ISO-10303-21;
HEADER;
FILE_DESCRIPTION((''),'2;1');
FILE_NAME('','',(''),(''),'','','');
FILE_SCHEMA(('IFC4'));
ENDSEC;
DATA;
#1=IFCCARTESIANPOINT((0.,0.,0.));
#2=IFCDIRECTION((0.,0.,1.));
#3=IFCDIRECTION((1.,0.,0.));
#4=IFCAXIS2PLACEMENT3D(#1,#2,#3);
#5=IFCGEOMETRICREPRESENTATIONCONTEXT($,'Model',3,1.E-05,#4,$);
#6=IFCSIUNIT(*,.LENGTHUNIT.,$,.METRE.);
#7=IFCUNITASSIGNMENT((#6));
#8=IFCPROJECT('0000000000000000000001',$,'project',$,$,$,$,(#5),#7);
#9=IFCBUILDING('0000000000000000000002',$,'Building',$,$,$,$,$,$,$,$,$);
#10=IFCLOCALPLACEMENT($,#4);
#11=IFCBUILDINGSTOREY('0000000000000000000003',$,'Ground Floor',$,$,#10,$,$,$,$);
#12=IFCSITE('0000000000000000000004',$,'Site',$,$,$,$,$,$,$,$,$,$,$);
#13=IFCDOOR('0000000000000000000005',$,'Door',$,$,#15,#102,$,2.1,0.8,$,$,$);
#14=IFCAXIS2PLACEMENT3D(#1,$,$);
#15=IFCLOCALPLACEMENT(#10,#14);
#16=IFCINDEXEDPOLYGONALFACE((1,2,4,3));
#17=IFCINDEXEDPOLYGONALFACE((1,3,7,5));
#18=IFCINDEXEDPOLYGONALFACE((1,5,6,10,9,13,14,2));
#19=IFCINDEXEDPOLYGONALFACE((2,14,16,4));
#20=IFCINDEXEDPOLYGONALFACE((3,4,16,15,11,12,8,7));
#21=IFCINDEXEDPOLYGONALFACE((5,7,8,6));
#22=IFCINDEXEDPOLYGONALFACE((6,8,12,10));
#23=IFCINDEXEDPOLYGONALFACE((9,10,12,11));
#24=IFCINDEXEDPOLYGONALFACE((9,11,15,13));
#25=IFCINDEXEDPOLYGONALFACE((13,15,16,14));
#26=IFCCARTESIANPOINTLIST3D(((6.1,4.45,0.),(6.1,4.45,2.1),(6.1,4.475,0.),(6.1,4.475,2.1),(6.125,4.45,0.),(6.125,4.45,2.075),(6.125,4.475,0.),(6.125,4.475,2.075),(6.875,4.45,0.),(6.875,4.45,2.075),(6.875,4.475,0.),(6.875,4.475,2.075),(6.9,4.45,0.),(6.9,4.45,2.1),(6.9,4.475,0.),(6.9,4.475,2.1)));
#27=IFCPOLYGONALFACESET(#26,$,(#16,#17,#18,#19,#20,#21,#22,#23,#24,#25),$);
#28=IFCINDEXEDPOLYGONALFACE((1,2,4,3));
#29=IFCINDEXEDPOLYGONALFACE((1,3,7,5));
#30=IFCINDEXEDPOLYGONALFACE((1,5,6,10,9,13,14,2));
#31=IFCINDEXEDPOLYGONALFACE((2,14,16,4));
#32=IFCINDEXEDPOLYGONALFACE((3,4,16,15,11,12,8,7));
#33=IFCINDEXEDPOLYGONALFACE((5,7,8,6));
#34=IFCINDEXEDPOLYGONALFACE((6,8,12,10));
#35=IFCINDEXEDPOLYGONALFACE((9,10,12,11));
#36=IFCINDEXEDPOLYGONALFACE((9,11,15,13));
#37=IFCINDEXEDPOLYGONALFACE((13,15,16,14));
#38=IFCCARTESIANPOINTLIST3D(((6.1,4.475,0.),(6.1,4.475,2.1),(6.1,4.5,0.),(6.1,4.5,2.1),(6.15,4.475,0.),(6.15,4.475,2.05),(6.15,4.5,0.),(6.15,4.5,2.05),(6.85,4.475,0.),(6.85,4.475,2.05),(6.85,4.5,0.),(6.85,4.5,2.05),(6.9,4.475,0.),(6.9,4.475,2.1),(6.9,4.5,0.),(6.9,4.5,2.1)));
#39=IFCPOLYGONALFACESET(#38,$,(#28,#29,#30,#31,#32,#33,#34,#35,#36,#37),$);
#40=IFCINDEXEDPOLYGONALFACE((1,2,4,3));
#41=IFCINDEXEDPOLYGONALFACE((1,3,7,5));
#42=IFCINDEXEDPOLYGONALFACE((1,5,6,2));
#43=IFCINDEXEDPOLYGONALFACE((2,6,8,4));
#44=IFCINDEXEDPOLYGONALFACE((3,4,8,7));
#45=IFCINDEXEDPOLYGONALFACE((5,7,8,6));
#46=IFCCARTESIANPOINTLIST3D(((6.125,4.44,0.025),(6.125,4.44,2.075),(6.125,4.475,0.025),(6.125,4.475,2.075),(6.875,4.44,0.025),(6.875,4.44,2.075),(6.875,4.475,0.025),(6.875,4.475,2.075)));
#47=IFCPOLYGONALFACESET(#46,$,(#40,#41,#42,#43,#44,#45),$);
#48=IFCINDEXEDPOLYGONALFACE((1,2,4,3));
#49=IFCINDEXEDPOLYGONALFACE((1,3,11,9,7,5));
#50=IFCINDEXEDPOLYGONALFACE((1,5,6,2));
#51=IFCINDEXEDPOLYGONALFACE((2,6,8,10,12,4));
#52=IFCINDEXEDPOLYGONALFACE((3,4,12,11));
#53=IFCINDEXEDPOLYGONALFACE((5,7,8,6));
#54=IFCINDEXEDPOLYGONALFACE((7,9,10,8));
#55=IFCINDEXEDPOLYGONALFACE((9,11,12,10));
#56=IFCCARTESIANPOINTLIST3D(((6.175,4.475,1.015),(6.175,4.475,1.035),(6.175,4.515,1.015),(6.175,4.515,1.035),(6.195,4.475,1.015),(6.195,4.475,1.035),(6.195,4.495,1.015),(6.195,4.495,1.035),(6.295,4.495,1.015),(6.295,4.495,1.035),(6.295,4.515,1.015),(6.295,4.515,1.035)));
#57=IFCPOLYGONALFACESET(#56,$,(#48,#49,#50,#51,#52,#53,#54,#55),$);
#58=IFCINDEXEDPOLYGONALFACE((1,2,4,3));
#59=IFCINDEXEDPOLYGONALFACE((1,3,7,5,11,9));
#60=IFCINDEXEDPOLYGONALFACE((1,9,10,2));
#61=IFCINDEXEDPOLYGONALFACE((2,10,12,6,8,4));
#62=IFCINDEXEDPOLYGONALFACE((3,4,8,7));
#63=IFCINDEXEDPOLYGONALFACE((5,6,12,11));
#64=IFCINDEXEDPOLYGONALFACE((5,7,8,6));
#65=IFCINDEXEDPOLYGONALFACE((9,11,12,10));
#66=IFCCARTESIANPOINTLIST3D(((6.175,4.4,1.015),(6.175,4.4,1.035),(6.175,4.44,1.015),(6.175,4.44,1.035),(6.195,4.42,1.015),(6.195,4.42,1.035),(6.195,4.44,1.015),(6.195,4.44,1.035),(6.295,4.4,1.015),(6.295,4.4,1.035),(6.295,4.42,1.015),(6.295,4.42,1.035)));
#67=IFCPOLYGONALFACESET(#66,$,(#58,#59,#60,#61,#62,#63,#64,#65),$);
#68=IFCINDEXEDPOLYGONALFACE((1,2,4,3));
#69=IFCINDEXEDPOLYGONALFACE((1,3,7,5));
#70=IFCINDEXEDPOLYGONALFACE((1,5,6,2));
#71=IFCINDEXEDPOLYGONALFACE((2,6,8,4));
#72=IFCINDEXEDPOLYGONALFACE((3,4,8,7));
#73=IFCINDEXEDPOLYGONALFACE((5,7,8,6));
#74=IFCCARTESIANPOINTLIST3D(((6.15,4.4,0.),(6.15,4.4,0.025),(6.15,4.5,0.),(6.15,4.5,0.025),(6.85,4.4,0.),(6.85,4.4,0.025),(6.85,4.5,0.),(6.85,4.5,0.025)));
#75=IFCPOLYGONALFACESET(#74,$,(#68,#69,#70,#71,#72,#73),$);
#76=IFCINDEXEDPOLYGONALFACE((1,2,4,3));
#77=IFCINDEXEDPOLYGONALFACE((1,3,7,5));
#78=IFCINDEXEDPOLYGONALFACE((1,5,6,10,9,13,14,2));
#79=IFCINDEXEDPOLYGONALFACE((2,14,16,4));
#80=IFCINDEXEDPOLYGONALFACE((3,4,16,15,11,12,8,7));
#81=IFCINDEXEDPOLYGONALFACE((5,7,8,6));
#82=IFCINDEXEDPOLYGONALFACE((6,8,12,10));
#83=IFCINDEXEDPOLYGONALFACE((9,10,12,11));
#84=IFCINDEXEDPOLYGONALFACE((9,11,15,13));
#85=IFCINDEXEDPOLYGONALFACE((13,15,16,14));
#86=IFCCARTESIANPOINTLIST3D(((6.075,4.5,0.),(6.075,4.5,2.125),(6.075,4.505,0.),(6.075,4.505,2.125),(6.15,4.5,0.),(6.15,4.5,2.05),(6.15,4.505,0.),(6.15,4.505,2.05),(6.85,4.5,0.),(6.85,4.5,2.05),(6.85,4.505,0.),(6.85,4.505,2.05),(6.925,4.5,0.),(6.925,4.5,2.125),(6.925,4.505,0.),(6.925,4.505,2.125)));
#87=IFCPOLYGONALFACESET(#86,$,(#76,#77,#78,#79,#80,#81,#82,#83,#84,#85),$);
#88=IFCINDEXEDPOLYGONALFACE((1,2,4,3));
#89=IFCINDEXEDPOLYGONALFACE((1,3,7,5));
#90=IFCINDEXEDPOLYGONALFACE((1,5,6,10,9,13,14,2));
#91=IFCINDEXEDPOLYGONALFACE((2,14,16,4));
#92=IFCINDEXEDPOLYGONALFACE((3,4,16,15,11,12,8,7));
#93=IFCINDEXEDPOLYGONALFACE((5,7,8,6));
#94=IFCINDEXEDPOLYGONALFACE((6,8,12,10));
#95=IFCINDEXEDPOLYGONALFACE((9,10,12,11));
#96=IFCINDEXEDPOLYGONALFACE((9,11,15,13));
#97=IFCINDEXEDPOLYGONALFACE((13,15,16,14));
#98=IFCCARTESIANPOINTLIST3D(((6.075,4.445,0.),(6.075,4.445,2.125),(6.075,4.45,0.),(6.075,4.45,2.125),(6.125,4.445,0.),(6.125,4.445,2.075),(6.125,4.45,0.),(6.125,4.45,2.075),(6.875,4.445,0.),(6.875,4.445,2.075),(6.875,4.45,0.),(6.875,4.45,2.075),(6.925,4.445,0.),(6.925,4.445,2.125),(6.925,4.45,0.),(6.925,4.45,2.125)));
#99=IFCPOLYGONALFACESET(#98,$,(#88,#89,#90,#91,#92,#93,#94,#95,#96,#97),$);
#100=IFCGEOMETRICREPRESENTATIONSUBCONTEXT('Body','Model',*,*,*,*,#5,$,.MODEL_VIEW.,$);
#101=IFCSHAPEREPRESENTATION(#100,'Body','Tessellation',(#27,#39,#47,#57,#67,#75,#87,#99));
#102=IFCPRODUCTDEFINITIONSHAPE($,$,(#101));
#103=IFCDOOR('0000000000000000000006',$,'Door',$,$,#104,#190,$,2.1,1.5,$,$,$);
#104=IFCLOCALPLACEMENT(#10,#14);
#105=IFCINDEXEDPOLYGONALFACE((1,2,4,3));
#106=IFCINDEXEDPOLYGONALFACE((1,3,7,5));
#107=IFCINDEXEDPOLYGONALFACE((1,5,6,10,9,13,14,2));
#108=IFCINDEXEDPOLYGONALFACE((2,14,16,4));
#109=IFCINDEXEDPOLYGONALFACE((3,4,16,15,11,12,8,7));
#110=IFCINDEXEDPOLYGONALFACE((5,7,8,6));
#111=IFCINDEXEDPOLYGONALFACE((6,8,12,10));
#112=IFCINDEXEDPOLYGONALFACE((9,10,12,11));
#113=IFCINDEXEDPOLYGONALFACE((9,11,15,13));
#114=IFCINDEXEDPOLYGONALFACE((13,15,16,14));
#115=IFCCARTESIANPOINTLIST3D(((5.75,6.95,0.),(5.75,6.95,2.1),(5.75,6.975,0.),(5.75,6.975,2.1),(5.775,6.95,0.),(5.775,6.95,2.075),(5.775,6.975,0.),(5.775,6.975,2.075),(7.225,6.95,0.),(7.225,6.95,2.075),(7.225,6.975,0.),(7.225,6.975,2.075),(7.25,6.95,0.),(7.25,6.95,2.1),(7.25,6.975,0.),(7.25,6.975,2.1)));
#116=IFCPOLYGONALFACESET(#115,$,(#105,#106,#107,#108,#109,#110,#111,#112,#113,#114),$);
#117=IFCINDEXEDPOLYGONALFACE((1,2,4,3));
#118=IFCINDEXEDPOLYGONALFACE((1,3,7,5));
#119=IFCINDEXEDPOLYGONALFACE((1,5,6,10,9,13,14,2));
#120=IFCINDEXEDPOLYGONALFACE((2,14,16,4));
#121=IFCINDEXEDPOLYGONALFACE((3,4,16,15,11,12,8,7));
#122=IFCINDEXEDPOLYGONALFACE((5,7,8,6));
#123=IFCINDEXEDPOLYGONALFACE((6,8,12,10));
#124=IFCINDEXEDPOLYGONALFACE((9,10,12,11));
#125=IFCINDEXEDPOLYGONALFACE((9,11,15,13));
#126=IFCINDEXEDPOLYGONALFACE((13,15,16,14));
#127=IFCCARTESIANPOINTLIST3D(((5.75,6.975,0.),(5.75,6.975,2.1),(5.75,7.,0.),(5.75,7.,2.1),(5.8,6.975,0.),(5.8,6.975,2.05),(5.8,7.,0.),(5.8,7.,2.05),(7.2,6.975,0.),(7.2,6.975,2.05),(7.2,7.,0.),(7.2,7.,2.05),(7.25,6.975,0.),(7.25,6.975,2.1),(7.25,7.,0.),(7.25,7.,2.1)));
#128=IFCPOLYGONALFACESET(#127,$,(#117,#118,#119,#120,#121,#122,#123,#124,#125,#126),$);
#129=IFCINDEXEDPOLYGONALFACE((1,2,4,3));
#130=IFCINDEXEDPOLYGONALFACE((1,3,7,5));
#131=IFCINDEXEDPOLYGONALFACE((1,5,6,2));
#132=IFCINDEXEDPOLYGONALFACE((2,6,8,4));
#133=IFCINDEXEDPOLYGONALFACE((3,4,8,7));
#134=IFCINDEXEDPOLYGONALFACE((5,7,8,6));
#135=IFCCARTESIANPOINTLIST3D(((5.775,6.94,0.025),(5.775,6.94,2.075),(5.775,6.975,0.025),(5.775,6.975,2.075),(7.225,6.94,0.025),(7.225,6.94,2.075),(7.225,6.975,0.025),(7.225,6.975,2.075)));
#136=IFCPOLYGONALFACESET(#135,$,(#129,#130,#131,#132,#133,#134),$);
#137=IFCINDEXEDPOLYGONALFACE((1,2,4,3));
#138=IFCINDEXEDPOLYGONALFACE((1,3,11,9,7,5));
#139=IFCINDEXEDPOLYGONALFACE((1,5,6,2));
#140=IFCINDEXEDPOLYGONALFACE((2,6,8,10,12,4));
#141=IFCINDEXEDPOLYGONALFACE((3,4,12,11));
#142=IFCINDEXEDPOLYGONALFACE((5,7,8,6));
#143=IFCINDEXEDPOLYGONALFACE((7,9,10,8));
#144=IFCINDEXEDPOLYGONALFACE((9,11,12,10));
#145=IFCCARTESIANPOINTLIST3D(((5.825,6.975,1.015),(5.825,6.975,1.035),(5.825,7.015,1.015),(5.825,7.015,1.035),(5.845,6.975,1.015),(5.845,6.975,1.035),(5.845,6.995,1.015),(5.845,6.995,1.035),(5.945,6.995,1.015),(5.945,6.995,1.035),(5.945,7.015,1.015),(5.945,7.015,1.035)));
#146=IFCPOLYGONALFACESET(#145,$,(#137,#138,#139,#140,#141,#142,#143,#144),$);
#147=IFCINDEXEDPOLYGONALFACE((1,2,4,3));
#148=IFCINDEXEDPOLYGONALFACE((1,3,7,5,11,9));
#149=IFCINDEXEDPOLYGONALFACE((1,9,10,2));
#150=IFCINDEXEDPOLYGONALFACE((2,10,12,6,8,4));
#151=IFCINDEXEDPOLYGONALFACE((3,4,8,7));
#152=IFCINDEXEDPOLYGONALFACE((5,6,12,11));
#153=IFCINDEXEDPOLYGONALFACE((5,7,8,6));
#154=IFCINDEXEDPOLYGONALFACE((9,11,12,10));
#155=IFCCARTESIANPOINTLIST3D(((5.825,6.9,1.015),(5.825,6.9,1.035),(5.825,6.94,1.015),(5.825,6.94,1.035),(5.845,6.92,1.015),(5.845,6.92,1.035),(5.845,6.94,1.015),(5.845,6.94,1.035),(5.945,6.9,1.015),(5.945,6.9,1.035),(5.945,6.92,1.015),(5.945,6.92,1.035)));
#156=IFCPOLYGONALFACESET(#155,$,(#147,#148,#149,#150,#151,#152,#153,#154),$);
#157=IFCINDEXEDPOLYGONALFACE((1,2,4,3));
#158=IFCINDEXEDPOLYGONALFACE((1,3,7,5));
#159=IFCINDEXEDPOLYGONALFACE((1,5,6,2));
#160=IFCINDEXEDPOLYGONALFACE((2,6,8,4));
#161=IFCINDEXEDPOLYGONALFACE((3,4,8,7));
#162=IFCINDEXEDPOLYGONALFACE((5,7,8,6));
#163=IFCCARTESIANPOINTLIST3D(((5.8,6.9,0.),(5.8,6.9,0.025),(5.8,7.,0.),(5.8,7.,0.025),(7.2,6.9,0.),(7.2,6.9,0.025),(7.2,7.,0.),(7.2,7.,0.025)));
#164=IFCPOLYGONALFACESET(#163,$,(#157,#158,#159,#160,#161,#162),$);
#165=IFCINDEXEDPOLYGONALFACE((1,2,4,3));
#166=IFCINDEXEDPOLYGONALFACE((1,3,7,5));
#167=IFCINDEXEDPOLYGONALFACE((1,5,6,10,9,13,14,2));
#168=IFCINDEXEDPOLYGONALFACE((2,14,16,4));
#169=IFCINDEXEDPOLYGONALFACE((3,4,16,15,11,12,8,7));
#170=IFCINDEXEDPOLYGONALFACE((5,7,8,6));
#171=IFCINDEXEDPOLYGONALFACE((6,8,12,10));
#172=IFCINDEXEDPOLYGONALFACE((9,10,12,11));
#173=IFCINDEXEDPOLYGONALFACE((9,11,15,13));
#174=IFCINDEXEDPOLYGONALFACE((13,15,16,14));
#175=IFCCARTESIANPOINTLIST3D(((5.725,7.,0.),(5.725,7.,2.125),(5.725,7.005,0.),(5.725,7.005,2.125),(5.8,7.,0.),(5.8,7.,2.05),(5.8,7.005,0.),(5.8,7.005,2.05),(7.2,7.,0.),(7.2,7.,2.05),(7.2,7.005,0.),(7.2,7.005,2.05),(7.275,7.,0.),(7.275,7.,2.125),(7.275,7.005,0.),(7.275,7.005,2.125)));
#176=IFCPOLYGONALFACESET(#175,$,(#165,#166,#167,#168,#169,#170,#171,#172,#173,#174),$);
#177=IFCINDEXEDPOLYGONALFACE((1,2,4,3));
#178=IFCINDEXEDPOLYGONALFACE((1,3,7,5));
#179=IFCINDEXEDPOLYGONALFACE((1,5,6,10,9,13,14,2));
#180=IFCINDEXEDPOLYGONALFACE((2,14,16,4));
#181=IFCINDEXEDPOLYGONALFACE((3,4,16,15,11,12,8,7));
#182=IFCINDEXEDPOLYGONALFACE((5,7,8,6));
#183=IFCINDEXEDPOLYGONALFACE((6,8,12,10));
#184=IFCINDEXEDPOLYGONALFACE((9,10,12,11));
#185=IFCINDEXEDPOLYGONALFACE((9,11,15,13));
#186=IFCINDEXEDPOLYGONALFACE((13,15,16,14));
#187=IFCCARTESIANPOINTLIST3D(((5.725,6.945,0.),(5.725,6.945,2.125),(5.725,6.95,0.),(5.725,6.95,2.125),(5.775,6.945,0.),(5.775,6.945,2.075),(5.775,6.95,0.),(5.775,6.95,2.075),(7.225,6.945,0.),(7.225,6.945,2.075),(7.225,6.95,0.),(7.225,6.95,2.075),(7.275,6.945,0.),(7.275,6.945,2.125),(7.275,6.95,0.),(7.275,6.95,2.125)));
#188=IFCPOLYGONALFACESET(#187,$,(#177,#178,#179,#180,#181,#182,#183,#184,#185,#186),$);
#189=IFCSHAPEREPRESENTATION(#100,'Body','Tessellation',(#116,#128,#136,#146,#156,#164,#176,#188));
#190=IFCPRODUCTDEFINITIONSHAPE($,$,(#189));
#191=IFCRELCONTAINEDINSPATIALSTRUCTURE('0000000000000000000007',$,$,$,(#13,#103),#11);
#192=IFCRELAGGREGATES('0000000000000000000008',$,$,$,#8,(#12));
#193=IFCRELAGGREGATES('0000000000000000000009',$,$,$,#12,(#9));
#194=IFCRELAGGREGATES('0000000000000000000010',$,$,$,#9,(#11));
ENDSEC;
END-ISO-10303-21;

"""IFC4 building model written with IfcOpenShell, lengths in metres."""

from ifc_helpers import new_model, si_unit, frame, origin_with_axes, place, context, subcontext, project, spatial, line, indexed_curve, outline, extrude, element, save


model = new_model("IFC4")

# Units and contexts
model_context = context("Model", 3, precision=1e-05, world=origin_with_axes())
body_context = subcontext(model_context, "Body", "Model", "MODEL_VIEW")
ifc_project = project(units=[si_unit("LENGTHUNIT", "METRE")], contexts=[model_context])

# Site, building, storey
site = spatial("IfcSite", under=ifc_project, Name="Site")
building = spatial("IfcBuilding", under=site, Name="Building")
storey_placement = place(None, origin_with_axes())
storey = spatial("IfcBuildingStorey", under=building, at=storey_placement, Name="Ground Floor")

# Doors
door_1_placement = place(storey_placement, frame((6.9, 4.5, 0.0), z_axis=(0.0, 0.0, 1.0), x_axis=(-1.0, 0.0, 0.0)))
element("IfcDoor", 1, at=door_1_placement, inside=storey, Name="Door", OverallHeight=2.1, OverallWidth=0.8, context=body_context, shape_type="SweptSolid", body=[
    extrude(outline(indexed_curve([(0.0, 0.0), (0.0, 2.1), (0.8, 2.1), (0.8, 0.0), (0.775, 0.0), (0.775, 2.075), (0.025, 2.075), (0.025, 0.0)], segments=[line(1, 2, 3, 4, 5, 6, 7, 8, 1)])), frame((0.0, 0.025, 0.0), z_axis=(0.0, -1.0, 0.0), x_axis=(1.0, 0.0, 0.0)), (0.0, 0.0, -1.0), 0.025),
    extrude(outline(indexed_curve([(0.0, 0.0), (0.0, 2.1), (0.8, 2.1), (0.8, 0.0), (0.75, 0.0), (0.75, 2.05), (0.05, 2.05), (0.05, 0.0)], segments=[line(1, 2, 3, 4, 5, 6, 7, 8, 1)])), frame((0.0, 0.0, 0.0), z_axis=(0.0, -1.0, 0.0), x_axis=(1.0, 0.0, 0.0)), (0.0, 0.0, -1.0), 0.025),
    extrude(outline(indexed_curve([(0.0, 0.0), (0.75, 0.0), (0.75, 0.035), (0.0, 0.035)], segments=[line(1, 2, 3, 4, 1)])), frame((0.025, 0.025, 0.025), z_axis=(0.0, 0.0, 1.0), x_axis=(1.0, 0.0, 0.0)), (0.0, 0.0, 1.0), 2.05),
    extrude(outline(indexed_curve([(0.0, 0.0), (0.0, -0.04), (-0.12, -0.04), (-0.12, -0.02), (-0.02, -0.02), (-0.02, 0.0)], segments=[line(1, 2, 3, 4, 5, 6, 1)])), frame((0.725, 0.025, 1.015), z_axis=(0.0, 0.0, 1.0), x_axis=(1.0, 0.0, 0.0)), (0.0, 0.0, 1.0), 0.02),
    extrude(outline(indexed_curve([(0.0, 0.0), (0.0, 0.04), (-0.12, 0.04), (-0.12, 0.02), (-0.02, 0.02), (-0.02, 0.0)], segments=[line(1, 2, 3, 4, 5, 6, 1)])), frame((0.725, 0.06, 1.015), z_axis=(0.0, 0.0, 1.0), x_axis=(1.0, 0.0, 0.0)), (0.0, 0.0, 1.0), 0.02),
    extrude(outline(indexed_curve([(0.0, 0.0), (0.7, 0.0), (0.7, 0.1), (0.0, 0.1)], segments=[line(1, 2, 3, 4, 1)])), frame((0.05, 0.0, 0.0), z_axis=(0.0, 0.0, 1.0), x_axis=(1.0, 0.0, 0.0)), (0.0, 0.0, 1.0), 0.025),
    extrude(outline(indexed_curve([(0.0, 0.0), (0.0, 2.125), (0.85, 2.125), (0.85, 0.0), (0.775, 0.0), (0.775, 2.05), (0.075, 2.05), (0.075, 0.0)], segments=[line(1, 2, 3, 4, 5, 6, 7, 8, 1)])), frame((-0.025, -0.005, 0.0), z_axis=(0.0, -1.0, 0.0), x_axis=(1.0, 0.0, 0.0)), (0.0, 0.0, -1.0), 0.005),
    extrude(outline(indexed_curve([(0.0, 0.0), (0.0, 2.125), (0.85, 2.125), (0.85, 0.0), (0.8, 0.0), (0.8, 2.075), (0.05, 2.075), (0.05, 0.0)], segments=[line(1, 2, 3, 4, 5, 6, 7, 8, 1)])), frame((-0.025, 0.05, 0.0), z_axis=(0.0, -1.0, 0.0), x_axis=(1.0, 0.0, 0.0)), (0.0, 0.0, -1.0), 0.005),
])
door_2_placement = place(storey_placement, frame((7.25, 7.0, 0.0), z_axis=(0.0, 0.0, 1.0), x_axis=(-1.0, 0.0, 0.0)))
element("IfcDoor", 2, at=door_2_placement, inside=storey, Name="Door", OverallHeight=2.1, OverallWidth=1.5, context=body_context, shape_type="SweptSolid", body=[
    extrude(outline(indexed_curve([(0.0, 0.0), (0.0, 2.1), (1.5, 2.1), (1.5, 0.0), (1.475, 0.0), (1.475, 2.075), (0.025, 2.075), (0.025, 0.0)], segments=[line(1, 2, 3, 4, 5, 6, 7, 8, 1)])), frame((0.0, 0.025, 0.0), z_axis=(0.0, -1.0, 0.0), x_axis=(1.0, 0.0, 0.0)), (0.0, 0.0, -1.0), 0.025),
    extrude(outline(indexed_curve([(0.0, 0.0), (0.0, 2.1), (1.5, 2.1), (1.5, 0.0), (1.45, 0.0), (1.45, 2.05), (0.05, 2.05), (0.05, 0.0)], segments=[line(1, 2, 3, 4, 5, 6, 7, 8, 1)])), frame((0.0, 0.0, 0.0), z_axis=(0.0, -1.0, 0.0), x_axis=(1.0, 0.0, 0.0)), (0.0, 0.0, -1.0), 0.025),
    extrude(outline(indexed_curve([(0.0, 0.0), (1.45, 0.0), (1.45, 0.035), (0.0, 0.035)], segments=[line(1, 2, 3, 4, 1)])), frame((0.025, 0.025, 0.025), z_axis=(0.0, 0.0, 1.0), x_axis=(1.0, 0.0, 0.0)), (0.0, 0.0, 1.0), 2.05),
    extrude(outline(indexed_curve([(0.0, 0.0), (0.0, -0.04), (-0.12, -0.04), (-0.12, -0.02), (-0.02, -0.02), (-0.02, 0.0)], segments=[line(1, 2, 3, 4, 5, 6, 1)])), frame((1.425, 0.025, 1.015), z_axis=(0.0, 0.0, 1.0), x_axis=(1.0, 0.0, 0.0)), (0.0, 0.0, 1.0), 0.02),
    extrude(outline(indexed_curve([(0.0, 0.0), (0.0, 0.04), (-0.12, 0.04), (-0.12, 0.02), (-0.02, 0.02), (-0.02, 0.0)], segments=[line(1, 2, 3, 4, 5, 6, 1)])), frame((1.425, 0.06, 1.015), z_axis=(0.0, 0.0, 1.0), x_axis=(1.0, 0.0, 0.0)), (0.0, 0.0, 1.0), 0.02),
    extrude(outline(indexed_curve([(0.0, 0.0), (1.4, 0.0), (1.4, 0.1), (0.0, 0.1)], segments=[line(1, 2, 3, 4, 1)])), frame((0.05, 0.0, 0.0), z_axis=(0.0, 0.0, 1.0), x_axis=(1.0, 0.0, 0.0)), (0.0, 0.0, 1.0), 0.025),
    extrude(outline(indexed_curve([(0.0, 0.0), (0.0, 2.125), (1.55, 2.125), (1.55, 0.0), (1.475, 0.0), (1.475, 2.05), (0.075, 2.05), (0.075, 0.0)], segments=[line(1, 2, 3, 4, 5, 6, 7, 8, 1)])), frame((-0.025, -0.005, 0.0), z_axis=(0.0, -1.0, 0.0), x_axis=(1.0, 0.0, 0.0)), (0.0, 0.0, -1.0), 0.005),
    extrude(outline(indexed_curve([(0.0, 0.0), (0.0, 2.125), (1.55, 2.125), (1.55, 0.0), (1.5, 0.0), (1.5, 2.075), (0.05, 2.075), (0.05, 0.0)], segments=[line(1, 2, 3, 4, 5, 6, 7, 8, 1)])), frame((-0.025, 0.05, 0.0), z_axis=(0.0, -1.0, 0.0), x_axis=(1.0, 0.0, 0.0)), (0.0, 0.0, -1.0), 0.005),
])

save(model, "model.ifc")
